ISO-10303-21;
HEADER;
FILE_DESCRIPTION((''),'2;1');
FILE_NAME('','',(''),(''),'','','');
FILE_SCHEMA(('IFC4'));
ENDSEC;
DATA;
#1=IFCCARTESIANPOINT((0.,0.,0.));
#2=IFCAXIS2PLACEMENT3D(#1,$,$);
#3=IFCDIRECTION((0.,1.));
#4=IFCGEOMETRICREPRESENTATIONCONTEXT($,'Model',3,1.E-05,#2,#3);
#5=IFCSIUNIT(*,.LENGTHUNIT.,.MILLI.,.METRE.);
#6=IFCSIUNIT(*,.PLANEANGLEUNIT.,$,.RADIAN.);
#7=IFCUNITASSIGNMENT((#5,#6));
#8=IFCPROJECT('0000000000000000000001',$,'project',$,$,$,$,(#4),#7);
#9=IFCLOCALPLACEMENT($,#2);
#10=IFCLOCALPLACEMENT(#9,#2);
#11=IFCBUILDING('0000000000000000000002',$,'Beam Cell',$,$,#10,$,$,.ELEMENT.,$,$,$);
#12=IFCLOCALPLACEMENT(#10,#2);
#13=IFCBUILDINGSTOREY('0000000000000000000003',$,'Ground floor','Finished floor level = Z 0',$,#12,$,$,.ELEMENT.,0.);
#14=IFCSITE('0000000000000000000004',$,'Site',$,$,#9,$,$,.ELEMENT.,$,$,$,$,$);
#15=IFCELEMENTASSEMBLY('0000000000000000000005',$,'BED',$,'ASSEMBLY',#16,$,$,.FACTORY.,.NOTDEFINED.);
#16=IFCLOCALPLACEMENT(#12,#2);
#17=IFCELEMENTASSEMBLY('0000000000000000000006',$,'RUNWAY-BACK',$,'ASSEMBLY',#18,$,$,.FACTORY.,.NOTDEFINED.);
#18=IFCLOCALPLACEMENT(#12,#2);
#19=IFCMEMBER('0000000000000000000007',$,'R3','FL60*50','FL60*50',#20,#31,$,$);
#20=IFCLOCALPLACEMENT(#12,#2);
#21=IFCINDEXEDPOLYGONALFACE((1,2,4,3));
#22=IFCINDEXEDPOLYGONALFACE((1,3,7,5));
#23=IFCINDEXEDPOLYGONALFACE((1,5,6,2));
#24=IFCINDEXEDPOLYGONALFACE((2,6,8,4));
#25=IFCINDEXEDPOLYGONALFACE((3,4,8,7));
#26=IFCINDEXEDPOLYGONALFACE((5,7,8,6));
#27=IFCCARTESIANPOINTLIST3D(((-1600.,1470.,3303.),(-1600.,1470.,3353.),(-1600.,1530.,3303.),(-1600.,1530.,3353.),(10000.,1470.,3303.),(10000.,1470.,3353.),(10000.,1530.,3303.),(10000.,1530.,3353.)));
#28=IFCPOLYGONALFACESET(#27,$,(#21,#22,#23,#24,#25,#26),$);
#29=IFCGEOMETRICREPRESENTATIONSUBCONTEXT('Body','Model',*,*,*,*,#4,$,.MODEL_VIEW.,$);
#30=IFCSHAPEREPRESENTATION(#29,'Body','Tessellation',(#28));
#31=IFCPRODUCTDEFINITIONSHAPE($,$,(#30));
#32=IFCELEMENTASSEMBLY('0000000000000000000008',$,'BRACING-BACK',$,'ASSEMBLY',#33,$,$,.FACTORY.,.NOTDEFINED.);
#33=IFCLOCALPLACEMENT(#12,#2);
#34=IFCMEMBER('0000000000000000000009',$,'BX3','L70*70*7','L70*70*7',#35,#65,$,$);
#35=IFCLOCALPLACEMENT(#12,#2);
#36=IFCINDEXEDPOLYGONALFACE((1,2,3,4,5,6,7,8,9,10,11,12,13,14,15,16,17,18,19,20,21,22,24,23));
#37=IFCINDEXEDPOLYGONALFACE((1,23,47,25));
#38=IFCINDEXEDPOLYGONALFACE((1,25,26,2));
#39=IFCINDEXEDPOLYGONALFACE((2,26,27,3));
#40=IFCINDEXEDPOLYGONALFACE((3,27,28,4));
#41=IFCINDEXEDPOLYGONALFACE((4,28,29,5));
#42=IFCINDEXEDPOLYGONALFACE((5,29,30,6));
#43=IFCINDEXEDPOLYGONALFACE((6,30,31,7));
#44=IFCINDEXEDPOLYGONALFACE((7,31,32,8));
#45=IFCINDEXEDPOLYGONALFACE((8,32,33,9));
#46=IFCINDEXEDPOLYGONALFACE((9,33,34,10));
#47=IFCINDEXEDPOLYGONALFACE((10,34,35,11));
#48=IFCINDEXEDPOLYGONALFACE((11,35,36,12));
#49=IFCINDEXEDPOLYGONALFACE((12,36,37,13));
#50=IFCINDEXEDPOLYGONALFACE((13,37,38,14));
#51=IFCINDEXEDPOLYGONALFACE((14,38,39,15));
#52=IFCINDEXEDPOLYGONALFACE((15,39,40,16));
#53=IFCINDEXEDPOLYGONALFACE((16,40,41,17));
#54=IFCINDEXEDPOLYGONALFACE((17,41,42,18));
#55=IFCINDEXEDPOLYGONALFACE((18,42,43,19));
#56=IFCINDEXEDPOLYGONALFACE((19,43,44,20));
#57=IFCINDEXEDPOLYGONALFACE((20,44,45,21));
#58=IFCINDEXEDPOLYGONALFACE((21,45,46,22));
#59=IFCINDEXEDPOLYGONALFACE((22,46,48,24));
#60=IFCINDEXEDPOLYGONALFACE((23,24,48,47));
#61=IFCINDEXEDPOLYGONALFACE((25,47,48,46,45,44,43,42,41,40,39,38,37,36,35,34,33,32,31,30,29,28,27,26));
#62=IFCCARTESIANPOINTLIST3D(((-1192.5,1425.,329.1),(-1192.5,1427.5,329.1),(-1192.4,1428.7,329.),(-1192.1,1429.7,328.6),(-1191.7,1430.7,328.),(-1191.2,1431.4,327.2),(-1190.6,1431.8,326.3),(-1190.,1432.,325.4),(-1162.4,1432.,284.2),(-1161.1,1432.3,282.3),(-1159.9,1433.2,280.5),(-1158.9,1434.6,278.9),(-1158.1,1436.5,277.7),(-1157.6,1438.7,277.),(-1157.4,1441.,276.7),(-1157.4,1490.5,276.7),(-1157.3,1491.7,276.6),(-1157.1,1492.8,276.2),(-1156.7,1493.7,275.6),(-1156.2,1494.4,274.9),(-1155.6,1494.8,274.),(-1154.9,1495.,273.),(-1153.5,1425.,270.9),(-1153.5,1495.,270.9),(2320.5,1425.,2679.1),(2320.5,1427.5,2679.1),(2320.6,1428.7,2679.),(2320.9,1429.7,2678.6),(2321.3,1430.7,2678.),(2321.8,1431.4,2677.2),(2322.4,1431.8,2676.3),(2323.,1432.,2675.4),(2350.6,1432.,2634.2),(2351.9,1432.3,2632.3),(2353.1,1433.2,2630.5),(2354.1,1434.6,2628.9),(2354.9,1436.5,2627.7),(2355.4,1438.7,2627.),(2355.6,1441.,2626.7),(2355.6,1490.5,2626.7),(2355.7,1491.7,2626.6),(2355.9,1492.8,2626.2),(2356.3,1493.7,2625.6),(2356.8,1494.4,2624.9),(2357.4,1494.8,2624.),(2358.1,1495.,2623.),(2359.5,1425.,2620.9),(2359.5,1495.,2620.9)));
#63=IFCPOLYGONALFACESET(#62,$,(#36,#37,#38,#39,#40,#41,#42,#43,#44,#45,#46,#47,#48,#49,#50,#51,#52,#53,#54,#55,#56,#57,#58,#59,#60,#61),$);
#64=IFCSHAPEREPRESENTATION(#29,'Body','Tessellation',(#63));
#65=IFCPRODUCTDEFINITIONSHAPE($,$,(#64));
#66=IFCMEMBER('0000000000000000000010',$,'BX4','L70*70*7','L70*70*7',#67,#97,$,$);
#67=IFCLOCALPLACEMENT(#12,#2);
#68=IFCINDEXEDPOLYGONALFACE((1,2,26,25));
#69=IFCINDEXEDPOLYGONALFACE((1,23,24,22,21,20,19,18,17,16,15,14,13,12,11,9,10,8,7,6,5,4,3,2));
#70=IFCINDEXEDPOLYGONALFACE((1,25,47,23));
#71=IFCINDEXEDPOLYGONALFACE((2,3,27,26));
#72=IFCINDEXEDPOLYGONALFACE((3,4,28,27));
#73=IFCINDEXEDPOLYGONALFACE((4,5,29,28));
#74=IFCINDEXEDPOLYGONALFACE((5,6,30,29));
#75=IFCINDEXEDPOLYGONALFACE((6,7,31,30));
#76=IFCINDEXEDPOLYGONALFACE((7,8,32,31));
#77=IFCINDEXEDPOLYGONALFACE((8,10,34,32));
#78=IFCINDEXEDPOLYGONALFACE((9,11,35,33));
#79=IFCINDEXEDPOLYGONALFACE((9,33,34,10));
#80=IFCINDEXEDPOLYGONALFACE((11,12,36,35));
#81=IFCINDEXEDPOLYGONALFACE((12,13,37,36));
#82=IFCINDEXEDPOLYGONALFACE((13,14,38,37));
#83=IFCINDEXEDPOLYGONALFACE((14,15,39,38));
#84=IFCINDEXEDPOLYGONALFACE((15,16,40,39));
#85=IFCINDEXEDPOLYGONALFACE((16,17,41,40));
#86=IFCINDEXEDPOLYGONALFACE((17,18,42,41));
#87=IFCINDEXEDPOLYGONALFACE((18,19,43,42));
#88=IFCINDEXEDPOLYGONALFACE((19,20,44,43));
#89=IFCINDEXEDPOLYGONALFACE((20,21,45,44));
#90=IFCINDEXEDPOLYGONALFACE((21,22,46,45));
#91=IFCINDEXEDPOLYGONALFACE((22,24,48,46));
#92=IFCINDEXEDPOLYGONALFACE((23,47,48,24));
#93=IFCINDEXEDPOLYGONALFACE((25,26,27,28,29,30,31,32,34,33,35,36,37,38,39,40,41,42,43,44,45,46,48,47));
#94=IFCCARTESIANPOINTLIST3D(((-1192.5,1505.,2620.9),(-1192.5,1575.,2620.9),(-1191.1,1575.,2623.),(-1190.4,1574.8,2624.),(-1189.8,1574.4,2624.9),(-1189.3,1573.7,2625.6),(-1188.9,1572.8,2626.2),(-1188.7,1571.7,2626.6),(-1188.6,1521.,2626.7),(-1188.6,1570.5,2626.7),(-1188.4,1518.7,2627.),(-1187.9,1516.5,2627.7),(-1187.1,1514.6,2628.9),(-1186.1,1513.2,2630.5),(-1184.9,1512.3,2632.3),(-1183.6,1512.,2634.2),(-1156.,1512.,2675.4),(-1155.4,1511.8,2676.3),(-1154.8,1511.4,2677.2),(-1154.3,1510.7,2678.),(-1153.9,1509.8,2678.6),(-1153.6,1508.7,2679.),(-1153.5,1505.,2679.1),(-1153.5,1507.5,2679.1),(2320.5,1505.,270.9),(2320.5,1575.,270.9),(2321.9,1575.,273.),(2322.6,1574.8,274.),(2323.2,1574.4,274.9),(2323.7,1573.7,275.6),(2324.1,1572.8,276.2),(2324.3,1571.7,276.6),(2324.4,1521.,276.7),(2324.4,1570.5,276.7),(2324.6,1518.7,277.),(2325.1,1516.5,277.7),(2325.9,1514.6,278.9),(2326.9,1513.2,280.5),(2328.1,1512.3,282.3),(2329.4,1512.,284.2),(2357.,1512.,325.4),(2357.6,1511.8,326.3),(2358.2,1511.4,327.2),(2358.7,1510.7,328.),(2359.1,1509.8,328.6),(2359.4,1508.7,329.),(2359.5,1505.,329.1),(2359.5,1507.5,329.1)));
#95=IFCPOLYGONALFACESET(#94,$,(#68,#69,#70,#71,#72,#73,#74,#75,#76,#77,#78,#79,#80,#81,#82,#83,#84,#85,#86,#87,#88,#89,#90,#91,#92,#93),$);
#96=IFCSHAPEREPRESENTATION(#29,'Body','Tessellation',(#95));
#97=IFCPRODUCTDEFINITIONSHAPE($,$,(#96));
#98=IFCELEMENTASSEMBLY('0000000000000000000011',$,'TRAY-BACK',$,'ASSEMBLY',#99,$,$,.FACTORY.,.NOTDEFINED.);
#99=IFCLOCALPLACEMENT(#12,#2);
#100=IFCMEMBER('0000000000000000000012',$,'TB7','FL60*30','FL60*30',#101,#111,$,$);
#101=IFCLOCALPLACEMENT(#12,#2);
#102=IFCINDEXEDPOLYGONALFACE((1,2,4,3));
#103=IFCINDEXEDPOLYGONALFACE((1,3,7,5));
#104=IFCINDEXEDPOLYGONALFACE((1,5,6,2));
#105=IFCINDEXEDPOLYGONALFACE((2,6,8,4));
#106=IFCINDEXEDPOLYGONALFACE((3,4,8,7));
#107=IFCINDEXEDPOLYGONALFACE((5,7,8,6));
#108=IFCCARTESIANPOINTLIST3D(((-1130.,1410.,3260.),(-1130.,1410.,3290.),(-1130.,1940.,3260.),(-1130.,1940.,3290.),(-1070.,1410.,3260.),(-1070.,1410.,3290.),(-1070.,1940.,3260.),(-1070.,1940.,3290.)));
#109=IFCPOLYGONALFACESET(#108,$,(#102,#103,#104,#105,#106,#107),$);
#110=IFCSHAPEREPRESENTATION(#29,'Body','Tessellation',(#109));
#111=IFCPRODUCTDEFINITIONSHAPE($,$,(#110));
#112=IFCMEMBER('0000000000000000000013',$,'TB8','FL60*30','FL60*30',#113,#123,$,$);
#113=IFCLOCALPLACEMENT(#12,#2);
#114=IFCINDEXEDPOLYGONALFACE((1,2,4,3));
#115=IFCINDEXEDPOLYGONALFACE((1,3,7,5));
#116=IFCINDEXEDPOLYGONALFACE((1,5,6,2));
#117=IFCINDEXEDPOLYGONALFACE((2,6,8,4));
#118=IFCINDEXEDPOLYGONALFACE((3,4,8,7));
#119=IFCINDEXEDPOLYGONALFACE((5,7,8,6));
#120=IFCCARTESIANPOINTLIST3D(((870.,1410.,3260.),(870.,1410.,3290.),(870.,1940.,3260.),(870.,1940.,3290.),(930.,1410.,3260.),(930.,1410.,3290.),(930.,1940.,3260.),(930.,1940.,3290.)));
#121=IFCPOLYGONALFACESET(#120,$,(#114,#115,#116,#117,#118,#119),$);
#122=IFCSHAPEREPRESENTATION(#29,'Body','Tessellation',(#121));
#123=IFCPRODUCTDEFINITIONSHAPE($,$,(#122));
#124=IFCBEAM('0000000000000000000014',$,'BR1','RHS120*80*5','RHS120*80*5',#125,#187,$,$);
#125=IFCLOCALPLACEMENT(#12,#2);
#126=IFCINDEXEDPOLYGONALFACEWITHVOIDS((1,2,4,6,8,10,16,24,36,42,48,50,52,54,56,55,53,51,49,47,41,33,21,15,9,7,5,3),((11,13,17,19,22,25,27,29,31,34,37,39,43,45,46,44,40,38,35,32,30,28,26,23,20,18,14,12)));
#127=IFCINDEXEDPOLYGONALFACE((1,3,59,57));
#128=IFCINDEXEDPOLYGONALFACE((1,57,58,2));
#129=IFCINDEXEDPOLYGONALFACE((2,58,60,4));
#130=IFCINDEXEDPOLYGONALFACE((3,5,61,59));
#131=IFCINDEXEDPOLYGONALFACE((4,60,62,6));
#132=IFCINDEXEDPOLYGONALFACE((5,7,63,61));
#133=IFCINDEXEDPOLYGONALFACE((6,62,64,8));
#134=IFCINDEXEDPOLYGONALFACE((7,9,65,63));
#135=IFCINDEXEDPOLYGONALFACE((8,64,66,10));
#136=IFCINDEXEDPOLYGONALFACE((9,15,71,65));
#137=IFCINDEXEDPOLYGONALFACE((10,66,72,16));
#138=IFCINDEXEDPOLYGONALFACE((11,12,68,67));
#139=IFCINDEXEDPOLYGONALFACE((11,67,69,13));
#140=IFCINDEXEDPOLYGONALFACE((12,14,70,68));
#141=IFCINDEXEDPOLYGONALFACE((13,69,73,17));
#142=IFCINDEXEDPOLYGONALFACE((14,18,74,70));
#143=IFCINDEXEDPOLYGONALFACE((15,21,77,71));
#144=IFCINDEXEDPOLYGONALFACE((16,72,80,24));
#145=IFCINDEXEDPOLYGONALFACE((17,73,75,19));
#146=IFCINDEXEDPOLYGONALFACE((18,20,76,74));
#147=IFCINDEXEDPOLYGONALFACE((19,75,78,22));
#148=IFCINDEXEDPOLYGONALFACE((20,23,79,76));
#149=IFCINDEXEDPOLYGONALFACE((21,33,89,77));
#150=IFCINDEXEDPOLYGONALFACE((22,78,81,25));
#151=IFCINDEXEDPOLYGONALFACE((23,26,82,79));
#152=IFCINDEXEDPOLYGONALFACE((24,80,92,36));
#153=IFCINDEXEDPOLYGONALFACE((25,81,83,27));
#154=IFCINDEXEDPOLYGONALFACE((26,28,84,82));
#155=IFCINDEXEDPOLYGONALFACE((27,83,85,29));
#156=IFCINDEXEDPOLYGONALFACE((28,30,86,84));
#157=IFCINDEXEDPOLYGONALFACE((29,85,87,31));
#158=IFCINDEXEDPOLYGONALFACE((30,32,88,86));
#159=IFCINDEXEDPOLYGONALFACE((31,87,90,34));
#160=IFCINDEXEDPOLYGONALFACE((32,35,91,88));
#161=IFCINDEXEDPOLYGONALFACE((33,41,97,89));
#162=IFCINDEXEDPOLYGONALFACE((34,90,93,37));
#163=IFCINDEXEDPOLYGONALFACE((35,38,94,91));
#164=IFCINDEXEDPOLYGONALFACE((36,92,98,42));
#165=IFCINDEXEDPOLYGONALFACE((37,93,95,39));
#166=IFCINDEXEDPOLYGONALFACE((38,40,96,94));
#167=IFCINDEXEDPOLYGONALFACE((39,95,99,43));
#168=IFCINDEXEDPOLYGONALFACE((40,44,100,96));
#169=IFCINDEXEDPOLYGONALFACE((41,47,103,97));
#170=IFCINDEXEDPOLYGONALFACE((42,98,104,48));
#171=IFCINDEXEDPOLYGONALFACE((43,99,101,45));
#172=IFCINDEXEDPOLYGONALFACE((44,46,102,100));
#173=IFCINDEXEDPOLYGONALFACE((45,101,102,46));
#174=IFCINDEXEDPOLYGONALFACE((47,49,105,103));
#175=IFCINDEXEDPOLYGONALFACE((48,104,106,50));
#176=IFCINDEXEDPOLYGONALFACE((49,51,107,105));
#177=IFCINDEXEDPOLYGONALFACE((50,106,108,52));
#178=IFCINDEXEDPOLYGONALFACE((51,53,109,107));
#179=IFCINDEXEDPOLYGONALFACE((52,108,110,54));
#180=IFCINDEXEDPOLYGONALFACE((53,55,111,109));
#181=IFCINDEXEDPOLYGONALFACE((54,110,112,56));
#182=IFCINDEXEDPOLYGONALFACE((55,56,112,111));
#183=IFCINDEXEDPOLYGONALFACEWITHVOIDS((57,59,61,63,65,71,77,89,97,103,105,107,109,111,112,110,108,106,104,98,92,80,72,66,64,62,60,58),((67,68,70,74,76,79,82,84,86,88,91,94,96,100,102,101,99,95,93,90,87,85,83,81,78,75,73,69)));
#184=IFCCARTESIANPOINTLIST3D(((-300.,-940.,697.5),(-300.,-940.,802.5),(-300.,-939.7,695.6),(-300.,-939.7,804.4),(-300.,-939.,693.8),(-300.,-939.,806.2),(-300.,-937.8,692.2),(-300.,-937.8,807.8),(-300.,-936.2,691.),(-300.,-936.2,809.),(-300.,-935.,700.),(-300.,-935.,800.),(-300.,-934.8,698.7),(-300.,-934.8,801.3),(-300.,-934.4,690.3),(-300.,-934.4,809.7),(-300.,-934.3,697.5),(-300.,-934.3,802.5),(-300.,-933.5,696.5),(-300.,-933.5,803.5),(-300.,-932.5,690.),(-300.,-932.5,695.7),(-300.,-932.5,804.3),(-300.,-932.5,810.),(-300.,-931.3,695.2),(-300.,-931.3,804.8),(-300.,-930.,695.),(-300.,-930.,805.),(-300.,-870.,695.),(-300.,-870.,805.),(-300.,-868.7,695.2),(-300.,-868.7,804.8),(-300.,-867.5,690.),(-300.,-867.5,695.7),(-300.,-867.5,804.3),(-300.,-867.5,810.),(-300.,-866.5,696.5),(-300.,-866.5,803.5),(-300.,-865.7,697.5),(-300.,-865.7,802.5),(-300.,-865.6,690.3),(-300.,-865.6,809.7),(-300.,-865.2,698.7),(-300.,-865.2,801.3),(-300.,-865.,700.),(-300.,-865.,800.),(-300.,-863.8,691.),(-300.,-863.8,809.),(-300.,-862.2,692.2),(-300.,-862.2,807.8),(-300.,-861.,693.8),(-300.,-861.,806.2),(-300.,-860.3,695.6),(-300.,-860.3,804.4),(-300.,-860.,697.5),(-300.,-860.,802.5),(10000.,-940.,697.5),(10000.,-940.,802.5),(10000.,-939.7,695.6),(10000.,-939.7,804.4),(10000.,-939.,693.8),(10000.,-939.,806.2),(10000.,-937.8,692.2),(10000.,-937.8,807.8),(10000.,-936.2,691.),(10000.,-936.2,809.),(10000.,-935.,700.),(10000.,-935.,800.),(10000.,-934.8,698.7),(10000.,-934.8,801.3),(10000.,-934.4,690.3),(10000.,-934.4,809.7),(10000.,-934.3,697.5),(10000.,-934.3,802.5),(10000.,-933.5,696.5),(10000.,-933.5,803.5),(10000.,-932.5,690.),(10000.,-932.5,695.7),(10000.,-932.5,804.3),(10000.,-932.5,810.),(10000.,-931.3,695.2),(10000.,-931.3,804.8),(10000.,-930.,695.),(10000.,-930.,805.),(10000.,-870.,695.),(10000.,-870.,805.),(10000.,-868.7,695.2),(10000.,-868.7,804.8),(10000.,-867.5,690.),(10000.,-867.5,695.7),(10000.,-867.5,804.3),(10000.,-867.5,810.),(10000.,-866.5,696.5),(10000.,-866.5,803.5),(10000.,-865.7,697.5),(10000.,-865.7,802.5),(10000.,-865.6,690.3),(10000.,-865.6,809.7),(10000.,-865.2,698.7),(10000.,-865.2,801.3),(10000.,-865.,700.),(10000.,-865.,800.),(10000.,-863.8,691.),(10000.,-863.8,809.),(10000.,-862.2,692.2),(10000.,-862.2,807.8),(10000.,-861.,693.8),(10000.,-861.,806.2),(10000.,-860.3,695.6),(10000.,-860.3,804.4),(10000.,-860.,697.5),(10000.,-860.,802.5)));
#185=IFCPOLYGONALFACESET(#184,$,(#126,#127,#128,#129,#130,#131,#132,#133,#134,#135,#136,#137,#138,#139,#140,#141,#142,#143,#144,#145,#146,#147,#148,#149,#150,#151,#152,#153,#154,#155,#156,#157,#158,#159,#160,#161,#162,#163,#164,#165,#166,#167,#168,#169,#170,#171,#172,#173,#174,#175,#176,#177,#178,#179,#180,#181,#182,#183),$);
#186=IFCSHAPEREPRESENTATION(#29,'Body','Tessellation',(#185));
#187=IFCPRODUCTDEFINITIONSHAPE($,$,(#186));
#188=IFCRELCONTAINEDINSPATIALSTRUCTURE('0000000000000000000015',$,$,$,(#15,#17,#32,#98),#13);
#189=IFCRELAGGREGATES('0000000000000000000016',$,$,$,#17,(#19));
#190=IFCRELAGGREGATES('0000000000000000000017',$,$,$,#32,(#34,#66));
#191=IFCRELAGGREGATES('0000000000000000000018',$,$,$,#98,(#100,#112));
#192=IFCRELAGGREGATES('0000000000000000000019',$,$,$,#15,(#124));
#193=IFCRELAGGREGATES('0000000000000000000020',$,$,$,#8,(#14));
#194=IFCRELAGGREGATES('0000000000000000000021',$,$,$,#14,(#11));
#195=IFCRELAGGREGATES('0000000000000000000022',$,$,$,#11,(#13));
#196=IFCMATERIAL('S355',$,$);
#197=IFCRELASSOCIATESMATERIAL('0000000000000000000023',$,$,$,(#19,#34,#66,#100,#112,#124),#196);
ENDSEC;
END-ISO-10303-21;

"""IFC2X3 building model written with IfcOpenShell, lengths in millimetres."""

from ifc_helpers import new_model, si_unit, direction, frame, origin, origin_2d, place, context, subcontext, project, spatial, rectangle, hollow_rectangle, l_section, extrude, material, element, aggregate, save


model = new_model("IFC2X3")

# Units and contexts
model_context = context("Model", 3, precision=1e-05, world=origin(), true_north=direction((0.0, 1.0)))
body_context = subcontext(model_context, "Body", "Model", "MODEL_VIEW")
ifc_project = project(units=[si_unit("LENGTHUNIT", "METRE", prefix="MILLI"), si_unit("PLANEANGLEUNIT", "RADIAN")], contexts=[model_context])

# Site, building, storey
site_placement = place(None, origin())
site = spatial("IfcSite", under=ifc_project, at=site_placement, Name="Site", CompositionType="ELEMENT")
building_placement = place(site_placement, origin())
building = spatial("IfcBuilding", under=site, at=building_placement, Name="Beam Cell", CompositionType="ELEMENT")
storey_placement = place(building_placement, origin())
storey = spatial("IfcBuildingStorey", under=building, at=storey_placement, Name="Ground floor", Description="Finished floor level = Z 0", CompositionType="ELEMENT", Elevation=0.0)

# Shared definitions
ifc_material = material(Name="S355")

# Element assembly
assembly_1_placement = place(storey_placement, origin())
assembly_1 = element("IfcElementAssembly", 1, at=assembly_1_placement, inside=storey, Name="BED", ObjectType="ASSEMBLY", AssemblyPlace="FACTORY", PredefinedType="NOTDEFINED")

# Element assembly, member
assembly_2_placement = place(storey_placement, origin())
assembly_2 = element("IfcElementAssembly", 2, at=assembly_2_placement, inside=storey, Name="RUNWAY-BACK", ObjectType="ASSEMBLY", AssemblyPlace="FACTORY", PredefinedType="NOTDEFINED")
member_1_placement = place(storey_placement, frame((-1600.0, 1500.0, 3328.0), z_axis=(1.0, 0.0, 0.0), x_axis=(0.0, 1.0, 0.0)))
member_1 = element("IfcMember", 3, at=member_1_placement, material=ifc_material, Name="R3", Description="FL60*50", ObjectType="FL60*50", context=body_context, shape_type="SweptSolid", body=[
    extrude(rectangle(XDim=60.0, YDim=50.0, at=origin_2d()), origin(), (0.0, 0.0, 1.0), 11600.0),
])
aggregate(assembly_2, [member_1])

# Element assemblies, members
assembly_3_placement = place(storey_placement, origin())
assembly_3 = element("IfcElementAssembly", 4, at=assembly_3_placement, inside=storey, Name="BRACING-BACK", ObjectType="ASSEMBLY", AssemblyPlace="FACTORY", PredefinedType="NOTDEFINED")
member_2_placement = place(storey_placement, frame((-1173.0, 1460.0, 300.0), z_axis=(0.831176, 0.0, 0.55601), x_axis=(0.0, 1.0, 0.0)))
member_2 = element("IfcMember", 5, at=member_2_placement, material=ifc_material, Name="BX3", Description="L70*70*7", ObjectType="L70*70*7", context=body_context, shape_type="SweptSolid", body=[
    extrude(l_section(Depth=70.0, Width=70.0, Thickness=7.0, FilletRadius=9.0, EdgeRadius=4.5, at=origin_2d()), origin(), (0.0, 0.0, 1.0), 4226.5),
])
member_3_placement = place(storey_placement, frame((-1173.0, 1540.0, 2650.0), z_axis=(0.831176, 0.0, -0.55601), x_axis=(0.0, 1.0, 0.0)))
member_3 = element("IfcMember", 6, at=member_3_placement, material=ifc_material, Name="BX4", Description="L70*70*7", ObjectType="L70*70*7", context=body_context, shape_type="SweptSolid", body=[
    extrude(l_section(Depth=70.0, Width=70.0, Thickness=7.0, FilletRadius=9.0, EdgeRadius=4.5, at=origin_2d()), origin(), (0.0, 0.0, 1.0), 4226.5),
])
aggregate(assembly_3, [member_2, member_3])
assembly_4_placement = place(storey_placement, origin())
assembly_4 = element("IfcElementAssembly", 7, at=assembly_4_placement, inside=storey, Name="TRAY-BACK", ObjectType="ASSEMBLY", AssemblyPlace="FACTORY", PredefinedType="NOTDEFINED")
member_4_placement = place(storey_placement, frame((-1100.0, 1410.0, 3275.0), z_axis=(0.0, 1.0, 0.0), x_axis=(1.0, 0.0, 0.0)))
member_4 = element("IfcMember", 8, at=member_4_placement, material=ifc_material, Name="TB7", Description="FL60*30", ObjectType="FL60*30", context=body_context, shape_type="SweptSolid", body=[
    extrude(rectangle(XDim=60.0, YDim=30.0, at=origin_2d()), origin(), (0.0, 0.0, 1.0), 530.0),
])
member_5_placement = place(storey_placement, frame((900.0, 1410.0, 3275.0), z_axis=(0.0, 1.0, 0.0), x_axis=(1.0, 0.0, 0.0)))
member_5 = element("IfcMember", 9, at=member_5_placement, material=ifc_material, Name="TB8", Description="FL60*30", ObjectType="FL60*30", context=body_context, shape_type="SweptSolid", body=[
    extrude(rectangle(XDim=60.0, YDim=30.0, at=origin_2d()), origin(), (0.0, 0.0, 1.0), 530.0),
])
aggregate(assembly_4, [member_4, member_5])

# Beam
beam_1_placement = place(storey_placement, frame((-300.0, -900.0, 750.0), z_axis=(1.0, 0.0, 0.0), x_axis=(0.0, 1.0, 0.0)))
beam_1 = element("IfcBeam", 10, at=beam_1_placement, material=ifc_material, Name="BR1", Description="RHS120*80*5", ObjectType="RHS120*80*5", context=body_context, shape_type="SweptSolid", body=[
    extrude(hollow_rectangle(XDim=80.0, YDim=120.0, WallThickness=5.0, InnerFilletRadius=5.0, OuterFilletRadius=7.5, at=origin_2d()), origin(), (0.0, 0.0, 1.0), 10300.0),
])
aggregate(assembly_1, [beam_1])

save(model, "model.ifc")
